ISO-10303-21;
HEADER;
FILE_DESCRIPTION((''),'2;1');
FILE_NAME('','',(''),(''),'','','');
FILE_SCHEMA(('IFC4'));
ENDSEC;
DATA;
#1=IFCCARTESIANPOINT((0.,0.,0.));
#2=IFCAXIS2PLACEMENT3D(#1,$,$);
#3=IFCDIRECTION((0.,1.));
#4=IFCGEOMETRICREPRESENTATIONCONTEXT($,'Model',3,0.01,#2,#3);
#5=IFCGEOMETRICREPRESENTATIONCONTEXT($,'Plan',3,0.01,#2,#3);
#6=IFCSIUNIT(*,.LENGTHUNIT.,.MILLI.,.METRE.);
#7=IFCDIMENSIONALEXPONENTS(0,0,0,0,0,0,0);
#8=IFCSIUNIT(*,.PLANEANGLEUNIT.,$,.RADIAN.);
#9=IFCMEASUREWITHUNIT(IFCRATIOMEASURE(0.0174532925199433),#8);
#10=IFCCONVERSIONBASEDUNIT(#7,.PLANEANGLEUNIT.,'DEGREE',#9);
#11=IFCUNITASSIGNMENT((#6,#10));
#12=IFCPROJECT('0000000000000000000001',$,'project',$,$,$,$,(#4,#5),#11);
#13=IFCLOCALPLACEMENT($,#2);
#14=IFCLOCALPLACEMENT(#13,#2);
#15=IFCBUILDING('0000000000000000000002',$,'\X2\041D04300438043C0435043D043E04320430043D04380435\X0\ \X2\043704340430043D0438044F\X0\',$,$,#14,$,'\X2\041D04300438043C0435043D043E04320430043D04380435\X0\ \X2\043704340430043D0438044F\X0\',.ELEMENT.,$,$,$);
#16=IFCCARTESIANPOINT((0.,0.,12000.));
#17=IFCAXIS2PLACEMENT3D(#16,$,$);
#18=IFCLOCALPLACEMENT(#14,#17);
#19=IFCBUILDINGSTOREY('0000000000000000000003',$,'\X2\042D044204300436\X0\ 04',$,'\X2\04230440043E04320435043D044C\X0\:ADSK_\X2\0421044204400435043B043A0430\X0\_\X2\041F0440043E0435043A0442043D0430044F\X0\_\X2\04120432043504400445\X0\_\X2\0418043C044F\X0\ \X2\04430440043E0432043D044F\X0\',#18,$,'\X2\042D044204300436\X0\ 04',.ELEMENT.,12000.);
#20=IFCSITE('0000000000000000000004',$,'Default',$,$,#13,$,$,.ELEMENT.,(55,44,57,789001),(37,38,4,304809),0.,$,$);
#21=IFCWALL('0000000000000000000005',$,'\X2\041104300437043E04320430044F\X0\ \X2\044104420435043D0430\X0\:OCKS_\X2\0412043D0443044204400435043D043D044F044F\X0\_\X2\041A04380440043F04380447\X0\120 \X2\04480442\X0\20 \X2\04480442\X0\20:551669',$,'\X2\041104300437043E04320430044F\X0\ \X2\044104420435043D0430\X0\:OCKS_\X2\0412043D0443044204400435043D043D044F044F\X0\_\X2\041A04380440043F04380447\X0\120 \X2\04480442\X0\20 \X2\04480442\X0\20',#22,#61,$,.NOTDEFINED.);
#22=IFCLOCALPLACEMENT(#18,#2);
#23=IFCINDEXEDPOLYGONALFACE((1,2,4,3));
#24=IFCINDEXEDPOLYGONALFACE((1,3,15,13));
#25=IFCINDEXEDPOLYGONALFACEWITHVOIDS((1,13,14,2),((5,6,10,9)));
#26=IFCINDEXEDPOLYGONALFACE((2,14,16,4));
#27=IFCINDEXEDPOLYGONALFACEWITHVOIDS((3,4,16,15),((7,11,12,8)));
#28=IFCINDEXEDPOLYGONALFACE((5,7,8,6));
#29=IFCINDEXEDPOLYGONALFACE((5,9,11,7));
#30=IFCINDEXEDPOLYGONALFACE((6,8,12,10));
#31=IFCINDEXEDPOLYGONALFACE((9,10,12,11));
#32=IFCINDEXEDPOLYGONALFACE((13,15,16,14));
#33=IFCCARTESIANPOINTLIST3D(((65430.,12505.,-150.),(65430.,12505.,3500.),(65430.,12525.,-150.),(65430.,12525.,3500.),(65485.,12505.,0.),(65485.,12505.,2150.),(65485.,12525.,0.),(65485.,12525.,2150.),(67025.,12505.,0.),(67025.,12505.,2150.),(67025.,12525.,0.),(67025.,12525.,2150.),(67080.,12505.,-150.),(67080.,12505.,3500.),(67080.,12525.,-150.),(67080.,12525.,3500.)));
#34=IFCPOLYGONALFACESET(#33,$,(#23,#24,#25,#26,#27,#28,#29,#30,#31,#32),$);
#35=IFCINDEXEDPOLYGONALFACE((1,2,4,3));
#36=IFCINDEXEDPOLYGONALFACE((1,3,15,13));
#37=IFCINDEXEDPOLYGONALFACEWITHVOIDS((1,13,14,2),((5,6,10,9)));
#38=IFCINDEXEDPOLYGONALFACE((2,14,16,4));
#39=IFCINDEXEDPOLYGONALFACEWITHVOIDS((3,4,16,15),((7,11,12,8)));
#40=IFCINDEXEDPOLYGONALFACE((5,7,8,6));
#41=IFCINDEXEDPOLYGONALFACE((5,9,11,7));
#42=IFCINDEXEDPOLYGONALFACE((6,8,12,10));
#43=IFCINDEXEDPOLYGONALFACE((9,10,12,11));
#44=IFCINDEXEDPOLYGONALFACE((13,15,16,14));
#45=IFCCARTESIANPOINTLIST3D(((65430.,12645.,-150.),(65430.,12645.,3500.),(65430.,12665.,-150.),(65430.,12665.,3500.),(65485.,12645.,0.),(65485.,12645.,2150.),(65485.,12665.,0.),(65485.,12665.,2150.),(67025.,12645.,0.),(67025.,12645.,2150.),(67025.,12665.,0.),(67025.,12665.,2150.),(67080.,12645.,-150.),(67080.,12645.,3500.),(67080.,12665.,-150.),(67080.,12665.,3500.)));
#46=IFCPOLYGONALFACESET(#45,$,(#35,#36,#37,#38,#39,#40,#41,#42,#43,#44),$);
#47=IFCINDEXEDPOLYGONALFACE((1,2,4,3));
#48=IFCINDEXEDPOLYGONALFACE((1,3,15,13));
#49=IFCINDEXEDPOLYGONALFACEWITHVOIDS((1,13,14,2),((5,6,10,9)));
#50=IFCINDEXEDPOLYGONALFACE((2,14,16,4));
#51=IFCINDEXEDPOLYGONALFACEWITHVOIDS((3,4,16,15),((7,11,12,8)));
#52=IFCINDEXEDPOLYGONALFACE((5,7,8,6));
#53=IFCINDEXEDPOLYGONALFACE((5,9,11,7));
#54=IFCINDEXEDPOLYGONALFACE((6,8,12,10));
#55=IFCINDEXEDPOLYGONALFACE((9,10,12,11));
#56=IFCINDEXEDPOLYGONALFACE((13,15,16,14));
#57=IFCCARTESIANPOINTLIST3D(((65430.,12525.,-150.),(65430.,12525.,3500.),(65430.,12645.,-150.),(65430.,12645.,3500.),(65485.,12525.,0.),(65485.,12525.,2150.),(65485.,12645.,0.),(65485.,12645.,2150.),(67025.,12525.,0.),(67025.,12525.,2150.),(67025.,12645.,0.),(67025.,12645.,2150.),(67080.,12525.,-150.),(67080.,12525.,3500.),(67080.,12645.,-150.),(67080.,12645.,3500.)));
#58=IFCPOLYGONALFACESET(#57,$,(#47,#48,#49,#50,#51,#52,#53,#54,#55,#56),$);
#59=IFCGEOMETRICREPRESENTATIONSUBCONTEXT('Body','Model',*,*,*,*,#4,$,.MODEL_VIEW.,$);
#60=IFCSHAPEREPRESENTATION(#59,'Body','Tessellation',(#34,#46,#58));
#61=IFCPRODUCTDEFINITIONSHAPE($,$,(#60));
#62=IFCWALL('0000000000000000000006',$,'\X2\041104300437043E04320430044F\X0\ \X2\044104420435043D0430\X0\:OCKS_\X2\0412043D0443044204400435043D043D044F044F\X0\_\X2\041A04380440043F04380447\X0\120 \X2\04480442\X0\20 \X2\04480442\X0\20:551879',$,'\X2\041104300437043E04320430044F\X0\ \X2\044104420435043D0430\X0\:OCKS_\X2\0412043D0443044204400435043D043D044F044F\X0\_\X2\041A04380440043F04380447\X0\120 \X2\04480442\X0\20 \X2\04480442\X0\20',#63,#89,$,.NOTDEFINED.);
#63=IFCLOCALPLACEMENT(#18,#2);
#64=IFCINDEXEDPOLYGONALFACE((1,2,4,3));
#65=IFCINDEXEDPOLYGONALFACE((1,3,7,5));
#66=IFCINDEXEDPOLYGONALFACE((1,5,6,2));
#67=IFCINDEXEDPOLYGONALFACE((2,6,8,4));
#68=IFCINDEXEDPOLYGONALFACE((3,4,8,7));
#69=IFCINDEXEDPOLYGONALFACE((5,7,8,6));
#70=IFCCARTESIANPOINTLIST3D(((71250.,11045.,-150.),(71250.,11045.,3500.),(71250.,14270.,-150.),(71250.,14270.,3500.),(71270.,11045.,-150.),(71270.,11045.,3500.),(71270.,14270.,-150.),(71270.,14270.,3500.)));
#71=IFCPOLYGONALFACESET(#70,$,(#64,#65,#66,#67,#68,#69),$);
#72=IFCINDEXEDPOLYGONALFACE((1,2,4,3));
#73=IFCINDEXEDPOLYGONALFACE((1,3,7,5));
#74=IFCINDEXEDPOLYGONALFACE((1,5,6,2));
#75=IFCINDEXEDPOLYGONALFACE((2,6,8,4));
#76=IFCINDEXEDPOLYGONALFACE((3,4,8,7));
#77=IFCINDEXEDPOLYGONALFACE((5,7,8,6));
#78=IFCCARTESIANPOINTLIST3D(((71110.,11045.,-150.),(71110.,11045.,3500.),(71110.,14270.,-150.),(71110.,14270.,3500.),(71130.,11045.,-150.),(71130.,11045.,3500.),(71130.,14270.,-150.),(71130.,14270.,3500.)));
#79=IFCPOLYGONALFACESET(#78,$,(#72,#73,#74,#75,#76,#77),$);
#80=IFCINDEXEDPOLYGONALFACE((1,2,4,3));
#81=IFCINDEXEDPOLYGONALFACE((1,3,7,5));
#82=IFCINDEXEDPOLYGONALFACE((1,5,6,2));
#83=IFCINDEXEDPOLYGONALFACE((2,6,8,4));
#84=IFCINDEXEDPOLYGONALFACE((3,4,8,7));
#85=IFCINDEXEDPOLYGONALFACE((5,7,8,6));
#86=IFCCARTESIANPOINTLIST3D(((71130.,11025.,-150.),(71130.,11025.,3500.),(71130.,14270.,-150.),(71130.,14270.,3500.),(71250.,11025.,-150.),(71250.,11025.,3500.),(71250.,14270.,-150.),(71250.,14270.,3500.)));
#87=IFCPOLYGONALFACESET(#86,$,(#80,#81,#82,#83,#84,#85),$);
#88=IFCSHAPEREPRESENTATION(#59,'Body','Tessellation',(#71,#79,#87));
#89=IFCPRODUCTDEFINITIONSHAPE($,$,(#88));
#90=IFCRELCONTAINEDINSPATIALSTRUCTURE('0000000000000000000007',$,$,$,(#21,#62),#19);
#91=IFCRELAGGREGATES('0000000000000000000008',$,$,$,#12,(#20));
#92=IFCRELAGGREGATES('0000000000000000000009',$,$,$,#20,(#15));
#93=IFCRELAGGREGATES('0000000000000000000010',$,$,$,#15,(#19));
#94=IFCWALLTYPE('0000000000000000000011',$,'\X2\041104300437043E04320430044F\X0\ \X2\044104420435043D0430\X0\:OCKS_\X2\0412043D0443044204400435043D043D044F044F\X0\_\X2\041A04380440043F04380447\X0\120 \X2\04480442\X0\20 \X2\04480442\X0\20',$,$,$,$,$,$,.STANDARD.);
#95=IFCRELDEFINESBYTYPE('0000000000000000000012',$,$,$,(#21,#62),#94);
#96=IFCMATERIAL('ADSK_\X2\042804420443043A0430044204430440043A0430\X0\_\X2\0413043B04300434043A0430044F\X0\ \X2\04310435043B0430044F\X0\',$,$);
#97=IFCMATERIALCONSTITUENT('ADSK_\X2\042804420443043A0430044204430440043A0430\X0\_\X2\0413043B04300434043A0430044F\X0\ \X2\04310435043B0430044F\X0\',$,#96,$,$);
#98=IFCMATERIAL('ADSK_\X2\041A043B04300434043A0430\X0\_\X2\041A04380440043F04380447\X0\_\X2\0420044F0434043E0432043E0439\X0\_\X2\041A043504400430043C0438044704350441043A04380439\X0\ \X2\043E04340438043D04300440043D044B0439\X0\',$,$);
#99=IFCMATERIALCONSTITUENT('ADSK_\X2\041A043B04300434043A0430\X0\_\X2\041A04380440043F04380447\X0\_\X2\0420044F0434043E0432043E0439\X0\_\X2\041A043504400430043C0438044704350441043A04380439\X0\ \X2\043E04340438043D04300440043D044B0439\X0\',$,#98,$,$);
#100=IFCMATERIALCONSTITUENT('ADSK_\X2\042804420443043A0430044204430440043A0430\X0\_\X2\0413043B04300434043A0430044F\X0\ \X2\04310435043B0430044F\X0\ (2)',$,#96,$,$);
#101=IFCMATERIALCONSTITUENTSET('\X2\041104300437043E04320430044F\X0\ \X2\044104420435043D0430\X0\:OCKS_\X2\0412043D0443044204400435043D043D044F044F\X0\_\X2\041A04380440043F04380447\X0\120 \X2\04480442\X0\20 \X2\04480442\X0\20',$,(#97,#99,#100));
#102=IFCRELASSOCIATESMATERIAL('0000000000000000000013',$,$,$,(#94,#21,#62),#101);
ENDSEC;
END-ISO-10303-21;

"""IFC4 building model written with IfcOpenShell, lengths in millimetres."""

from ifc_helpers import new_model, entity, si_unit, converted_unit, direction, frame, origin, place, context, subcontext, project, spatial, indexed_curve, outline, extrude, material, constituent, constituent_set, type_object, element, save


model = new_model("IFC4")

# Units and contexts
model_context = context("Model", 3, precision=0.01, world=origin(), true_north=direction((0.0, 1.0)))
plan_context = context("Plan", 3, precision=0.01, world=origin(), true_north=direction((0.0, 1.0)))
body_context = subcontext(model_context, "Body", "Model", "MODEL_VIEW")
ifc_project = project(units=[si_unit("LENGTHUNIT", "METRE", prefix="MILLI"), converted_unit("PLANEANGLEUNIT", "DEGREE", entity("IfcRatioMeasure", 0.0174532925199433), si_unit("PLANEANGLEUNIT", "RADIAN"), dimensions=[0, 0, 0, 0, 0, 0, 0])], contexts=[model_context, plan_context])

# Site, building, storey
site_placement = place(None, frame((0.0, 0.0, 0.0)))
site = spatial("IfcSite", under=ifc_project, at=site_placement, Name="Default", CompositionType="ELEMENT", RefLatitude=(55, 44, 57, 789001), RefLongitude=(37, 38, 4, 304809), RefElevation=0.0)
building_placement = place(site_placement, origin())
building = spatial("IfcBuilding", under=site, at=building_placement, Name="Наименование здания", LongName="Наименование здания", CompositionType="ELEMENT")
storey_placement = place(building_placement, frame((0.0, 0.0, 12000.0)))
storey = spatial("IfcBuildingStorey", under=building, at=storey_placement, Name="Этаж 04", ObjectType="Уровень:ADSK_Стрелка_Проектная_Вверх_Имя уровня", LongName="Этаж 04", CompositionType="ELEMENT", Elevation=12000.0)

# Shared definitions
ifc_material_1 = material(Name="ADSK_Штукатурка_Гладкая белая")
ifc_material_2 = material(Name="ADSK_Кладка_Кирпич_Рядовой_Керамический одинарный")

# Wall, opening
ifc_constituent_1 = constituent(ifc_material_1, Name="ADSK_Штукатурка_Гладкая белая")
ifc_constituent_2 = constituent(ifc_material_2, Name="ADSK_Кладка_Кирпич_Рядовой_Керамический одинарный")
ifc_constituent_3 = constituent(ifc_material_1, Name="ADSK_Штукатурка_Гладкая белая (2)")
ifc_constituent_set_1 = constituent_set(constituents=[ifc_constituent_1, ifc_constituent_2, ifc_constituent_3], Name="Базовая стена:OCKS_Внутренняя_Кирпич120 шт20 шт20")
wall_type_1 = type_object("IfcWallType", Name="Базовая стена:OCKS_Внутренняя_Кирпич120 шт20 шт20", PredefinedType="STANDARD", material=ifc_constituent_set_1)
wall_1_placement = place(storey_placement, frame((67080.0, 12585.0, -150.0), z_axis=(0.0, 0.0, 1.0), x_axis=(-1.0, 0.0, 0.0)))
wall_1 = element("IfcWall", 1, at=wall_1_placement, inside=storey, type_object=wall_type_1, material=ifc_constituent_set_1, Name="Базовая стена:OCKS_Внутренняя_Кирпич120 шт20 шт20:551669", ObjectType="Базовая стена:OCKS_Внутренняя_Кирпич120 шт20 шт20", PredefinedType="NOTDEFINED", context=body_context, shape_type="SweptSolid", body=[
    extrude(outline(indexed_curve([(-1825.0, -825.0), (1825.0, -825.0), (1825.0, 825.0), (-1825.0, 825.0), (-1825.0, -825.0)], self_intersect=False), holes=[indexed_curve([(475.0, 770.0), (475.0, -770.0), (-1675.0, -770.0), (-1675.0, 770.0), (475.0, 770.0)], self_intersect=False)]), frame((825.0, 80.0, 1825.0), z_axis=(0.0, -1.0, 0.0), x_axis=(0.0, 0.0, 1.0)), (0.0, 0.0, 1.0), 20.0),
    extrude(outline(indexed_curve([(-1825.0, -825.0), (1825.0, -825.0), (1825.0, 825.0), (-1825.0, 825.0), (-1825.0, -825.0)], self_intersect=False), holes=[indexed_curve([(475.0, 770.0), (475.0, -770.0), (-1675.0, -770.0), (-1675.0, 770.0), (475.0, 770.0)], self_intersect=False)]), frame((825.0, -60.0, 1825.0), z_axis=(0.0, -1.0, 0.0), x_axis=(0.0, 0.0, 1.0)), (0.0, 0.0, 1.0), 20.0),
    extrude(outline(indexed_curve([(-1825.0, -825.0), (1825.0, -825.0), (1825.0, 825.0), (-1825.0, 825.0), (-1825.0, -825.0)], self_intersect=False), holes=[indexed_curve([(475.0, 770.0), (475.0, -770.0), (-1675.0, -770.0), (-1675.0, 770.0), (475.0, 770.0)], self_intersect=False)]), frame((825.0, 60.0, 1825.0), z_axis=(0.0, -1.0, 0.0), x_axis=(0.0, 0.0, 1.0)), (0.0, 0.0, 1.0), 120.0),
])
opening_1_placement = place(wall_1_placement, frame((67080.0, 12585.0, 150.0), z_axis=(0.0, 0.0, 1.0), x_axis=(-1.0, 0.0, 0.0)))
element("IfcOpeningElement", 2, at=opening_1_placement, cuts=wall_1, PredefinedType="OPENING", context=body_context, shape_type="SweptSolid", body=[
    extrude(outline(indexed_curve([(-770.0, -1075.0), (770.0, -1075.0), (770.0, 1075.0), (-770.0, 1075.0), (-770.0, -1075.0)], self_intersect=False)), frame((66255.0, 13265.0, 1075.0), z_axis=(0.0, -1.0, 0.0), x_axis=(-1.0, 0.0, 0.0)), (0.0, 0.0, 1.0), 1360.0),
])

# Wall
wall_2_placement = place(storey_placement, frame((71190.0, 14270.0, -150.0), z_axis=(0.0, 0.0, 1.0), x_axis=(0.0, -1.0, 0.0)))
element("IfcWall", 3, at=wall_2_placement, inside=storey, type_object=wall_type_1, material=ifc_constituent_set_1, Name="Базовая стена:OCKS_Внутренняя_Кирпич120 шт20 шт20:551879", ObjectType="Базовая стена:OCKS_Внутренняя_Кирпич120 шт20 шт20", PredefinedType="NOTDEFINED", context=body_context, shape_type="SweptSolid", body=[
    extrude(outline(indexed_curve([(-10.0, -1612.5), (10.0, -1612.5), (10.0, 1612.5), (-10.0, 1612.5), (-10.0, -1612.5)], self_intersect=False)), frame((1612.5, 70.0, 0.0), z_axis=(0.0, 0.0, 1.0), x_axis=(0.0, -1.0, 0.0)), (0.0, 0.0, 1.0), 3650.0),
    extrude(outline(indexed_curve([(-10.0, -1612.5), (10.0, -1612.5), (10.0, 1612.5), (-10.0, 1612.5), (-10.0, -1612.5)], self_intersect=False)), frame((1612.5, -70.0, 0.0), z_axis=(0.0, 0.0, 1.0), x_axis=(0.0, 1.0, 0.0)), (0.0, 0.0, 1.0), 3650.0),
    extrude(outline(indexed_curve([(-1622.5, -60.0), (1622.5, -60.0), (1622.5, 60.0), (-1622.5, 60.0), (-1622.5, -60.0)], self_intersect=False)), frame((1622.5, 0.0, 0.0)), (0.0, 0.0, 1.0), 3650.0),
])

save(model, "model.ifc")
